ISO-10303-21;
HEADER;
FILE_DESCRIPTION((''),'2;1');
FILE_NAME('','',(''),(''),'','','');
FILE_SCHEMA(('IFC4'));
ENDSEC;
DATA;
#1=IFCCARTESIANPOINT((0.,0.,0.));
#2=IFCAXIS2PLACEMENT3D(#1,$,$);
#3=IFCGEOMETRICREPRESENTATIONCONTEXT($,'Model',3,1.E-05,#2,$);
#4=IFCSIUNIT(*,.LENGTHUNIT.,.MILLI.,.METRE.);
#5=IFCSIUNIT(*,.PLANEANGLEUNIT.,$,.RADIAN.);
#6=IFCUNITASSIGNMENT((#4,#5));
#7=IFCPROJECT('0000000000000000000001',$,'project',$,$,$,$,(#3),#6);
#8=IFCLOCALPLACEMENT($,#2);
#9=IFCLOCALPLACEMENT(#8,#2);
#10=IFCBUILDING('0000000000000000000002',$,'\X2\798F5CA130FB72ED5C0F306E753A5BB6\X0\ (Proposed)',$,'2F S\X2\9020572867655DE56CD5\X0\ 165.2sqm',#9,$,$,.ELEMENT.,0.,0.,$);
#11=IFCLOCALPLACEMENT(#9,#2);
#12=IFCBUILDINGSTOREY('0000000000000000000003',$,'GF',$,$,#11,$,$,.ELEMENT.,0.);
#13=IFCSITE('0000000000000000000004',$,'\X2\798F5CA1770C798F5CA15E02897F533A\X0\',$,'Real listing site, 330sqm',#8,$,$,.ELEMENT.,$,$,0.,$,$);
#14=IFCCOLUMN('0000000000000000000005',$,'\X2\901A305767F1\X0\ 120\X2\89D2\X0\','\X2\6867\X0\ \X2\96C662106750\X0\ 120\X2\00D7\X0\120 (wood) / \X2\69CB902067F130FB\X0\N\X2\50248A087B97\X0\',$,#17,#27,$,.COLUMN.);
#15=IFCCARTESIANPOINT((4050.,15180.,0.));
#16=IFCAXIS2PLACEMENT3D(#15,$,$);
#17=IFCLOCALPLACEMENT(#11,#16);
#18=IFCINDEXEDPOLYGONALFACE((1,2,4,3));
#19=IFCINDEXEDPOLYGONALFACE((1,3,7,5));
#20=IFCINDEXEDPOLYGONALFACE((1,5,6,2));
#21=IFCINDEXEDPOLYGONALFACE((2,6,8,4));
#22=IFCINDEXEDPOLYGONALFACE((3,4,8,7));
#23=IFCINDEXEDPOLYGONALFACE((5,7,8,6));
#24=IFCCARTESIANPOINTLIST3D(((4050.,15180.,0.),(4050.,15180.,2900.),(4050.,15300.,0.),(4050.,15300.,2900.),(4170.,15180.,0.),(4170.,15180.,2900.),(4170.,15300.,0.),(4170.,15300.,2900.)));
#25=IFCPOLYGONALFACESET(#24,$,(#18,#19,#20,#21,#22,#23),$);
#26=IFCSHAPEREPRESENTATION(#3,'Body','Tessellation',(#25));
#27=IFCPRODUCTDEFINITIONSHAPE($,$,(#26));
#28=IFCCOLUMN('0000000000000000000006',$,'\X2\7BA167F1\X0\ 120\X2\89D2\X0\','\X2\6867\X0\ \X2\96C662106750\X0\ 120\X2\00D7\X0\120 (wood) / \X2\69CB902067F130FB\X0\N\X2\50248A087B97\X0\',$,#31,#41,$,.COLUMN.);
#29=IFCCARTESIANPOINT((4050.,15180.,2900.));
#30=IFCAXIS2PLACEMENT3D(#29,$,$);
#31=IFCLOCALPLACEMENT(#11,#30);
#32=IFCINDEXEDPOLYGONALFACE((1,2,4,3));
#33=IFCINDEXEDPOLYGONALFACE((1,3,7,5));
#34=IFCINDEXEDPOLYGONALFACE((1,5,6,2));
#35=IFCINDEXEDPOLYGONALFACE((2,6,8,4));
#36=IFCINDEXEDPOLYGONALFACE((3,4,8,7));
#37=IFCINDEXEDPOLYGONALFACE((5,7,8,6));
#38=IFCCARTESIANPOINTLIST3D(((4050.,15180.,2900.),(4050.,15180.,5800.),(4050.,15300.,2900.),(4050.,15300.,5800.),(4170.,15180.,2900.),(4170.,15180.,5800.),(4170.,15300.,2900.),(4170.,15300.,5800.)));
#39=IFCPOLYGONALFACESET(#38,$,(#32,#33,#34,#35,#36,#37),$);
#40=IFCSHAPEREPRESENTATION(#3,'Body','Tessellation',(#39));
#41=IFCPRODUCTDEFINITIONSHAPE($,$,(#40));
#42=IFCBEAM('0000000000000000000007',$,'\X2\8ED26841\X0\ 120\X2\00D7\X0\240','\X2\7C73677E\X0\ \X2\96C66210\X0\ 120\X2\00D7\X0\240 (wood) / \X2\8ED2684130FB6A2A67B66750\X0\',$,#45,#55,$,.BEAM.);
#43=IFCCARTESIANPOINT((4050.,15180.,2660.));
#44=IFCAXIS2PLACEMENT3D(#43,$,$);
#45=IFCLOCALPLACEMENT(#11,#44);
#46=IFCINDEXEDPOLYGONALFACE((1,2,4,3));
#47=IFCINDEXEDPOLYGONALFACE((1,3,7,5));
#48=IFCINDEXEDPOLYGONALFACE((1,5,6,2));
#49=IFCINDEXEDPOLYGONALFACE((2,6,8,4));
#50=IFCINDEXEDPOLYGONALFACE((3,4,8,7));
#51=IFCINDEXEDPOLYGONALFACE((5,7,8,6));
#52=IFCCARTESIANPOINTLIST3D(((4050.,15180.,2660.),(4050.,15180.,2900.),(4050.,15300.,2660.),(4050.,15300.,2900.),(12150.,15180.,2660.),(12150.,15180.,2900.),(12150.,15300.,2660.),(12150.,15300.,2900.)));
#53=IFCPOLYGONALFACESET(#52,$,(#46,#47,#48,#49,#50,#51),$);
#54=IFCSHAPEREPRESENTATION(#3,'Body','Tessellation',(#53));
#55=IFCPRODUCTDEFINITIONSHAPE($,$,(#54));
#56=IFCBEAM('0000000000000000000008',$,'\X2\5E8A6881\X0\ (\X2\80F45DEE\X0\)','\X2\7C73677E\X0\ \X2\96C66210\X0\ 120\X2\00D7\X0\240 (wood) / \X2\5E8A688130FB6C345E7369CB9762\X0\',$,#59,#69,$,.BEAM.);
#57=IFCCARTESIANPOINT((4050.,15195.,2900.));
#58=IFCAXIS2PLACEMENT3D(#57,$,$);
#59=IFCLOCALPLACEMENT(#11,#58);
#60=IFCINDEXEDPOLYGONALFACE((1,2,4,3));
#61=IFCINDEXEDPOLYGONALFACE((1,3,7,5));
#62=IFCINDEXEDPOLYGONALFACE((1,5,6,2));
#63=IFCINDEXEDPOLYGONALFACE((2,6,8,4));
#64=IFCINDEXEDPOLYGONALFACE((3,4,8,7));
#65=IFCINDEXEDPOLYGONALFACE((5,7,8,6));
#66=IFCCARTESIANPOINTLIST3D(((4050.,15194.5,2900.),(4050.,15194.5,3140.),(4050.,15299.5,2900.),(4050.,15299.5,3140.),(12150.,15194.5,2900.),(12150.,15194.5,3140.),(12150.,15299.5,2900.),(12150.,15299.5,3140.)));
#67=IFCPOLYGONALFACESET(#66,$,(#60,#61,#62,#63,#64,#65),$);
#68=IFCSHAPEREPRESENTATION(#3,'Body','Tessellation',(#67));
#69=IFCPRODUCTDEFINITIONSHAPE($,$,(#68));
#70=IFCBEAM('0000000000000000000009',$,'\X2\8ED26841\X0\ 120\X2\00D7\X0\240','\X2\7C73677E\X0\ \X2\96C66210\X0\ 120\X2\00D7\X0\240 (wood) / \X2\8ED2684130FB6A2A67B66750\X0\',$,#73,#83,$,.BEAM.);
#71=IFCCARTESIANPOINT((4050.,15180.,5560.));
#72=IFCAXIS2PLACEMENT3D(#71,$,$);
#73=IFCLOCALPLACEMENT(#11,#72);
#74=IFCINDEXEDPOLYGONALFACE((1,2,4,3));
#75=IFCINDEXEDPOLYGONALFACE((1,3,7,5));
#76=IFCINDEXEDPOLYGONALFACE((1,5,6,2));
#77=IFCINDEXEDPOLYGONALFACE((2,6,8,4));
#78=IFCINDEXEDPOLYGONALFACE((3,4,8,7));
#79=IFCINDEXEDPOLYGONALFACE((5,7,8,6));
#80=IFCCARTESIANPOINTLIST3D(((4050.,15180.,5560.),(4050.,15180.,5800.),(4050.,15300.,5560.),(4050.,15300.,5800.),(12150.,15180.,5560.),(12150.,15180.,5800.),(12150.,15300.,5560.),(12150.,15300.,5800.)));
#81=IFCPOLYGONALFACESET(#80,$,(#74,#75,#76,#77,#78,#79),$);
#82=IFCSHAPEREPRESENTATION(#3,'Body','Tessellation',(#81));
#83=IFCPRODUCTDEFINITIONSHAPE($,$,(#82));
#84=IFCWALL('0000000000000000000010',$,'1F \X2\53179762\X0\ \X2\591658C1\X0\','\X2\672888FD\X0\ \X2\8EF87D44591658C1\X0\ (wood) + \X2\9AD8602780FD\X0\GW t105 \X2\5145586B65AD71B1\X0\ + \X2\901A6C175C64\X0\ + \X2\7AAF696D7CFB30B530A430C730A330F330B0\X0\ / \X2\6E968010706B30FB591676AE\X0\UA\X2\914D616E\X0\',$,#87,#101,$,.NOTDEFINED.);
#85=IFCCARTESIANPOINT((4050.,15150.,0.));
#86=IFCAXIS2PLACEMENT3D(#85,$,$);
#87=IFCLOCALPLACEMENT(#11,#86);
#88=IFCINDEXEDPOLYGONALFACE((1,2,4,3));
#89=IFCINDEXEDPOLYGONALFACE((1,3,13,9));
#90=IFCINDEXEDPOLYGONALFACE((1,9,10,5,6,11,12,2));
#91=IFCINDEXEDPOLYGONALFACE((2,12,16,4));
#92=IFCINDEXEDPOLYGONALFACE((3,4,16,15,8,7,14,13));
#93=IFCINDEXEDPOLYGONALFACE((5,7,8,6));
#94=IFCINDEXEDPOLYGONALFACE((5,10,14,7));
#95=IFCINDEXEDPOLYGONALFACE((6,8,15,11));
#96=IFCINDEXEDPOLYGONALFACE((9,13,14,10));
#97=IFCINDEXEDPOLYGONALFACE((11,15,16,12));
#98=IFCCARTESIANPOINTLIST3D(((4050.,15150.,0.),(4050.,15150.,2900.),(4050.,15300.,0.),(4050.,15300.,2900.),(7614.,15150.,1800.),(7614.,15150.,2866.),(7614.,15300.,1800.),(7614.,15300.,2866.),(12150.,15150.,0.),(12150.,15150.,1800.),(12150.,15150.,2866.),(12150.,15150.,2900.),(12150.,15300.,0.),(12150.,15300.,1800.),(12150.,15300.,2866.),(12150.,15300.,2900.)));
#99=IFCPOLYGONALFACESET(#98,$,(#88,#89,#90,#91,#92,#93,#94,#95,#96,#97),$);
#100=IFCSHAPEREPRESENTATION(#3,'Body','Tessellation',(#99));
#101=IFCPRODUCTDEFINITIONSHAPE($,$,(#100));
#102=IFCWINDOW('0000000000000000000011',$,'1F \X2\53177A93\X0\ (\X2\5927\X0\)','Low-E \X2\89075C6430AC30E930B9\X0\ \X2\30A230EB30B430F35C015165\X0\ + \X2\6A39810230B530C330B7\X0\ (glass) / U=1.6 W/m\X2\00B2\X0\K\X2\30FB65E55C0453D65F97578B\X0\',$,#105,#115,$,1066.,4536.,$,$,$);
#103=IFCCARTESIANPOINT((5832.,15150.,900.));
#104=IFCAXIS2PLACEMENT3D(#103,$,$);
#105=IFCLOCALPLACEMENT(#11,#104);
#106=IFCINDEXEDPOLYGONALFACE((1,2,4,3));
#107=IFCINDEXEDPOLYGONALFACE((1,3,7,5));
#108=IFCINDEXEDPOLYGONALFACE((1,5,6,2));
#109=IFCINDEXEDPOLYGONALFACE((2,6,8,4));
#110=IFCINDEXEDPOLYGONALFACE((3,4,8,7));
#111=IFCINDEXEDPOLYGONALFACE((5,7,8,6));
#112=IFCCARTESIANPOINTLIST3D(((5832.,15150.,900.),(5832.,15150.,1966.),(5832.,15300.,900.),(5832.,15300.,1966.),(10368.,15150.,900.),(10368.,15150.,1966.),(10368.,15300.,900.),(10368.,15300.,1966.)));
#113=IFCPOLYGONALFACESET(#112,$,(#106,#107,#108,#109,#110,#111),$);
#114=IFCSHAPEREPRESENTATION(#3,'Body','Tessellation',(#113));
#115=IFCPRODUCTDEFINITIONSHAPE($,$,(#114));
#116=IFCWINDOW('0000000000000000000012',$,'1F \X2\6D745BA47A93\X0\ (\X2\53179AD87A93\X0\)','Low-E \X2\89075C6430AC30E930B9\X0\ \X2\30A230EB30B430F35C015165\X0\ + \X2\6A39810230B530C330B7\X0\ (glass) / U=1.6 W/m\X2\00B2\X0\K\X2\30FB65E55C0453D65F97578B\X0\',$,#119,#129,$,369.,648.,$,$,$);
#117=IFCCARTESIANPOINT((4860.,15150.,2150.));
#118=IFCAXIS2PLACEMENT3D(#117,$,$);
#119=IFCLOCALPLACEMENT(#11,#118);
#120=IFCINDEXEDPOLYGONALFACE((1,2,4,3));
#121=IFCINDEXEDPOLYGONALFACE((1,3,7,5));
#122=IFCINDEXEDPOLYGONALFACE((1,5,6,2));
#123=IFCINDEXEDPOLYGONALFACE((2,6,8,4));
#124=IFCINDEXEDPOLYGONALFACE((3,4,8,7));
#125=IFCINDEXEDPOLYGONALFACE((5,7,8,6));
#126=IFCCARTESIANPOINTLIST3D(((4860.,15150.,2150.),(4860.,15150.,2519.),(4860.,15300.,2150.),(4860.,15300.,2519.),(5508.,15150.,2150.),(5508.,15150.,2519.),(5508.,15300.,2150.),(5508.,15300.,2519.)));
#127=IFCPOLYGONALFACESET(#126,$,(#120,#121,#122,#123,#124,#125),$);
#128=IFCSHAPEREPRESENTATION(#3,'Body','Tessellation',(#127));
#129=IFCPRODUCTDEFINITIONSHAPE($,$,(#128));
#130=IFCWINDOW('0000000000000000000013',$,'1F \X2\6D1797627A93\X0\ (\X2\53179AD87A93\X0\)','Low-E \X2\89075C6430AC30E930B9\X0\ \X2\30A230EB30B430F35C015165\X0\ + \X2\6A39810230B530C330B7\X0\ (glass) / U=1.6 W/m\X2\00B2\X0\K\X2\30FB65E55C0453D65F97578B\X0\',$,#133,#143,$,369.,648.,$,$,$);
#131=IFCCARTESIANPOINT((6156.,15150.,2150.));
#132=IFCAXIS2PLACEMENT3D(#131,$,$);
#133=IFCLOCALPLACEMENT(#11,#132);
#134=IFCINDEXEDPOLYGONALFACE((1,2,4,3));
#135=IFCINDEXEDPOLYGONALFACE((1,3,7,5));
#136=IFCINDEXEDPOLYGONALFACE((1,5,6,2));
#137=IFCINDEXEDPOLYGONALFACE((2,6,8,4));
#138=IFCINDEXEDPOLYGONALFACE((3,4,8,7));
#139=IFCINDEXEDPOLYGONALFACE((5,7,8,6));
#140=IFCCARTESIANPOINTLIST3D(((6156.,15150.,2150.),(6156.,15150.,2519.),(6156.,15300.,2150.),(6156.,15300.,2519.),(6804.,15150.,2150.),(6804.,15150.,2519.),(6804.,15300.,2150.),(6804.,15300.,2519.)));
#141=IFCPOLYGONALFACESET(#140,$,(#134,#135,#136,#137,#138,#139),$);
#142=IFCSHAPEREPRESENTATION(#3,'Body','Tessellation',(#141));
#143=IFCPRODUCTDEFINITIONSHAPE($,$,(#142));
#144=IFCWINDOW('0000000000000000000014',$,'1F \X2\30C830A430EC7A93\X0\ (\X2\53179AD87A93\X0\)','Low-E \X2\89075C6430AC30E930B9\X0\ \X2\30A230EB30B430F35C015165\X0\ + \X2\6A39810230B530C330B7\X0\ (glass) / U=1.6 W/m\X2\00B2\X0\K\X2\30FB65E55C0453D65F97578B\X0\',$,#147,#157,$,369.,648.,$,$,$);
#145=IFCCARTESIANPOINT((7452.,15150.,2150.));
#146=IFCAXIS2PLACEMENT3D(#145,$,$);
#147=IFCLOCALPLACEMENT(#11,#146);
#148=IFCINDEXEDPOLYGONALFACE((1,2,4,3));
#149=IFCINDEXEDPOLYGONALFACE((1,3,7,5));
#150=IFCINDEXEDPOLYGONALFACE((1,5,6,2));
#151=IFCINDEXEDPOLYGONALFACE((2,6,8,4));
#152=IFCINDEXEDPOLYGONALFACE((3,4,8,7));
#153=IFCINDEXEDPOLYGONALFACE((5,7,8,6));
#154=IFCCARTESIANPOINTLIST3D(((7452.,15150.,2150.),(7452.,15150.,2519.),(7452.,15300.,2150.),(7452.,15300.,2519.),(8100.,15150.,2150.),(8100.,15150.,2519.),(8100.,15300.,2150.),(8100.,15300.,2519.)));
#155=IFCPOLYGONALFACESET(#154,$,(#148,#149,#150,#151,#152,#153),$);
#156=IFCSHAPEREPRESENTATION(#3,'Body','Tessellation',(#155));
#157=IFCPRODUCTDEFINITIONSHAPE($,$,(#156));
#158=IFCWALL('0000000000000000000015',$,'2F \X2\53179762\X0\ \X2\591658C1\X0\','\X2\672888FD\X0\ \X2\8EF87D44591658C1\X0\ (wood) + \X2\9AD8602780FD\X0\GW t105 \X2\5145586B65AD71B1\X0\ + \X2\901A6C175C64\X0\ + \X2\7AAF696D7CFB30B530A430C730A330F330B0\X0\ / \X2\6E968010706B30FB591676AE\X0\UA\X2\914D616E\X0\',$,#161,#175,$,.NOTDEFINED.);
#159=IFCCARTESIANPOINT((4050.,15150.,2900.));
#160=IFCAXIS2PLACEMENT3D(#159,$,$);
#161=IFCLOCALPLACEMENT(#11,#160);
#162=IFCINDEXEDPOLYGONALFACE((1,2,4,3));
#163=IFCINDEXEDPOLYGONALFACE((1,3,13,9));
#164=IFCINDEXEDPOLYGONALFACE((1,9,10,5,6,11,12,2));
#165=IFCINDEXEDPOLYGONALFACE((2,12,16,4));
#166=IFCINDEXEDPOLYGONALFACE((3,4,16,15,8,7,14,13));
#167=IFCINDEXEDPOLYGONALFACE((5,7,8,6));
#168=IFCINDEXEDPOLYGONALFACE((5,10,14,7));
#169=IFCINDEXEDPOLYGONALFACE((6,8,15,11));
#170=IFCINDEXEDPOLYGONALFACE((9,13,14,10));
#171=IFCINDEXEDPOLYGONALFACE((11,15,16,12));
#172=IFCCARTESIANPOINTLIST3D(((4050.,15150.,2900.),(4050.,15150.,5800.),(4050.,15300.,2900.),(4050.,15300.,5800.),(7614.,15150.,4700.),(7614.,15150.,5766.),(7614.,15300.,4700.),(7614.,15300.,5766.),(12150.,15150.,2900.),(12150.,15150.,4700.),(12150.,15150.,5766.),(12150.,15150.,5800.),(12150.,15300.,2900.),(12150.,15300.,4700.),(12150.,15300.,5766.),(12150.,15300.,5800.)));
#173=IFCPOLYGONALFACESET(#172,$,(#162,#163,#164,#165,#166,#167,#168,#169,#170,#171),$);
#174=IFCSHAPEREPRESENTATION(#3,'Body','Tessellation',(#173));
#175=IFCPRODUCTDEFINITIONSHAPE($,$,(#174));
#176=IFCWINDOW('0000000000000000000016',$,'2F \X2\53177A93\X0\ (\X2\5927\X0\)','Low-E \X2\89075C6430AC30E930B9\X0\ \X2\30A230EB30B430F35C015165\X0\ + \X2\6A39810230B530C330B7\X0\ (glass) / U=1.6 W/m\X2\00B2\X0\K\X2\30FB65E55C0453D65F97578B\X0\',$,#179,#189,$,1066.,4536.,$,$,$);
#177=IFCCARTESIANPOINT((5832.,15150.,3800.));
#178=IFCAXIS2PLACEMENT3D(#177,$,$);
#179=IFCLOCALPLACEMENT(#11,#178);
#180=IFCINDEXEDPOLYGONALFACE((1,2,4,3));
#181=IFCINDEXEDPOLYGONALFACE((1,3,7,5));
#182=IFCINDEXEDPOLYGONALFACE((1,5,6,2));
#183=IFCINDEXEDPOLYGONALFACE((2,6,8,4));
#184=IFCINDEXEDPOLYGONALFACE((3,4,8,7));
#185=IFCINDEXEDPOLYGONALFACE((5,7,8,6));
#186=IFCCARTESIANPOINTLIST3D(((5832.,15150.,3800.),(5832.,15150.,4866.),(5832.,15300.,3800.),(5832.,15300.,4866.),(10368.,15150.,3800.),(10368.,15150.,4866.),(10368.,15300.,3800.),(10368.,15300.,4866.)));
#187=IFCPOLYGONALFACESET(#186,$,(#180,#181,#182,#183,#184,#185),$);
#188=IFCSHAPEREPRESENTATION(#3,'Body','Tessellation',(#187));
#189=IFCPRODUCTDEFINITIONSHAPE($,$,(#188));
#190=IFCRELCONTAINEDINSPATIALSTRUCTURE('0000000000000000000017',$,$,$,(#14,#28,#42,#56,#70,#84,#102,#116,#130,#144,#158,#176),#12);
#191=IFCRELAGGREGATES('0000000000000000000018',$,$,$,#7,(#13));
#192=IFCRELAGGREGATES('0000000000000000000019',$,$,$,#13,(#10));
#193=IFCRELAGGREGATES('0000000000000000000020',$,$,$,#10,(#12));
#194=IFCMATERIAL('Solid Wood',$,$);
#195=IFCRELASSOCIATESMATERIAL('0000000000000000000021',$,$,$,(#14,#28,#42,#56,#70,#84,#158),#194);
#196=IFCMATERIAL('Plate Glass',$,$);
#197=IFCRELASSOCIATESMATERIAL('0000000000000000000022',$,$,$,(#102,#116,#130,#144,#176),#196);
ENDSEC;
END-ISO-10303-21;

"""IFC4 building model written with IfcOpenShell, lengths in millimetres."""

from ifc_helpers import new_model, si_unit, frame, frame_2d, origin, place, context, project, spatial, rectangle, extrude, material, element, fill, save


model = new_model("IFC4")

# Units and contexts
model_context = context("Model", 3, precision=1e-05, world=origin())
ifc_project = project(units=[si_unit("LENGTHUNIT", "METRE", prefix="MILLI"), si_unit("PLANEANGLEUNIT", "RADIAN")], contexts=[model_context])

# Site, building, storey
site_placement = place(None, origin())
site = spatial("IfcSite", under=ifc_project, at=site_placement, Name="福岡県福岡市西区", ObjectType="Real listing site, 330sqm", CompositionType="ELEMENT", RefElevation=0.0)
building_placement = place(site_placement, origin())
building = spatial("IfcBuilding", under=site, at=building_placement, Name="福岡・狭小の町家 (Proposed)", ObjectType="2F S造在来工法 165.2sqm", CompositionType="ELEMENT", ElevationOfRefHeight=0.0, ElevationOfTerrain=0.0)
storey_placement = place(building_placement, origin())
storey = spatial("IfcBuildingStorey", under=building, at=storey_placement, Name="GF", CompositionType="ELEMENT", Elevation=0.0)

# Columns
ifc_material_1 = material(Name="Solid Wood")
column_1_placement = place(storey_placement, frame((4050.0, 15180.0, 0.0)))
element("IfcColumn", 1, at=column_1_placement, inside=storey, material=ifc_material_1, Name="通し柱 120角", Description="桧 集成材 120×120 (wood) / 構造柱・N値計算", PredefinedType="COLUMN", context=model_context, shape_type="SweptSolid", body=[
    extrude(rectangle(XDim=120.0, YDim=120.0, at=frame_2d((60.0, 60.0))), frame((4050.0, 15180.0, 0.0)), (0.0, 0.0, 1.0), 2900.0),
])
column_2_placement = place(storey_placement, frame((4050.0, 15180.0, 2900.0)))
element("IfcColumn", 2, at=column_2_placement, inside=storey, material=ifc_material_1, Name="管柱 120角", Description="桧 集成材 120×120 (wood) / 構造柱・N値計算", PredefinedType="COLUMN", context=model_context, shape_type="SweptSolid", body=[
    extrude(rectangle(XDim=120.0, YDim=120.0, at=frame_2d((60.0, 60.0))), frame((4050.0, 15180.0, 2900.0)), (0.0, 0.0, 1.0), 2900.0),
])

# Beams
beam_1_placement = place(storey_placement, frame((4050.0, 15180.0, 2660.0)))
element("IfcBeam", 3, at=beam_1_placement, inside=storey, material=ifc_material_1, Name="軒桁 120×240", Description="米松 集成 120×240 (wood) / 軒桁・横架材", PredefinedType="BEAM", context=model_context, shape_type="SweptSolid", body=[
    extrude(rectangle(XDim=8100.0, YDim=120.0, at=frame_2d((4050.0, 60.0))), frame((4050.0, 15180.0, 2660.0)), (0.0, 0.0, 1.0), 240.0),
])
beam_2_placement = place(storey_placement, frame((4050.0, 15195.0, 2900.0)))
element("IfcBeam", 4, at=beam_2_placement, inside=storey, material=ifc_material_1, Name="床梁 (胴差)", Description="米松 集成 120×240 (wood) / 床梁・水平構面", PredefinedType="BEAM", context=model_context, shape_type="SweptSolid", body=[
    extrude(rectangle(XDim=8100.0, YDim=105.0, at=frame_2d((4050.0, 52.0))), frame((4050.0, 15195.0, 2900.0)), (0.0, 0.0, 1.0), 240.0),
])
beam_3_placement = place(storey_placement, frame((4050.0, 15180.0, 5560.0)))
element("IfcBeam", 5, at=beam_3_placement, inside=storey, material=ifc_material_1, Name="軒桁 120×240", Description="米松 集成 120×240 (wood) / 軒桁・横架材", PredefinedType="BEAM", context=model_context, shape_type="SweptSolid", body=[
    extrude(rectangle(XDim=8100.0, YDim=120.0, at=frame_2d((4050.0, 60.0))), frame((4050.0, 15180.0, 5560.0)), (0.0, 0.0, 1.0), 240.0),
])

# Wall, openings, windows
wall_1_placement = place(storey_placement, frame((4050.0, 15150.0, 0.0)))
wall_1 = element("IfcWall", 6, at=wall_1_placement, inside=storey, material=ifc_material_1, Name="1F 北面 外壁", Description="木製 軸組外壁 (wood) + 高性能GW t105 充填断熱 + 通気層 + 窯業系サイディング / 準耐火・外皮UA配慮", PredefinedType="NOTDEFINED", context=model_context, shape_type="SweptSolid", body=[
    extrude(rectangle(XDim=8100.0, YDim=150.0, at=frame_2d((4050.0, 75.0))), frame((4050.0, 15150.0, 0.0)), (0.0, 0.0, 1.0), 2900.0),
])
opening_1_placement = place(storey_placement, frame((5832.0, 15150.0, 900.0)))
opening_1 = element("IfcOpeningElement", 7, at=opening_1_placement, cuts=wall_1, PredefinedType="NOTDEFINED", context=model_context, shape_type="SweptSolid", body=[
    extrude(rectangle(XDim=4536.0, YDim=150.0, at=frame_2d((2268.0, 75.0))), frame((5832.0, 15150.0, 900.0)), (0.0, 0.0, 1.0), 1066.0),
])
opening_2_placement = place(storey_placement, frame((4860.0, 15150.0, 2150.0)))
opening_2 = element("IfcOpeningElement", 8, at=opening_2_placement, cuts=wall_1, PredefinedType="NOTDEFINED", context=model_context, shape_type="SweptSolid", body=[
    extrude(rectangle(XDim=648.0, YDim=150.0, at=frame_2d((324.0, 75.0))), frame((4860.0, 15150.0, 2150.0)), (0.0, 0.0, 1.0), 369.0),
])
opening_3_placement = place(storey_placement, frame((6156.0, 15150.0, 2150.0)))
opening_3 = element("IfcOpeningElement", 9, at=opening_3_placement, cuts=wall_1, PredefinedType="NOTDEFINED", context=model_context, shape_type="SweptSolid", body=[
    extrude(rectangle(XDim=648.0, YDim=150.0, at=frame_2d((324.0, 75.0))), frame((6156.0, 15150.0, 2150.0)), (0.0, 0.0, 1.0), 369.0),
])
opening_4_placement = place(storey_placement, frame((7452.0, 15150.0, 2150.0)))
opening_4 = element("IfcOpeningElement", 10, at=opening_4_placement, cuts=wall_1, PredefinedType="NOTDEFINED", context=model_context, shape_type="SweptSolid", body=[
    extrude(rectangle(XDim=648.0, YDim=150.0, at=frame_2d((324.0, 75.0))), frame((7452.0, 15150.0, 2150.0)), (0.0, 0.0, 1.0), 369.0),
])
ifc_material_2 = material(Name="Plate Glass")
window_1_placement = place(storey_placement, frame((5832.0, 15150.0, 900.0)))
window_1 = element("IfcWindow", 11, at=window_1_placement, inside=storey, material=ifc_material_2, Name="1F 北窓 (大)", Description="Low-E 複層ガラス アルゴン封入 + 樹脂サッシ (glass) / U=1.6 W/m²K・日射取得型", OverallHeight=1066.0, OverallWidth=4536.0, context=model_context, shape_type="SweptSolid", body=[
    extrude(rectangle(XDim=4536.0, YDim=150.0, at=frame_2d((2268.0, 75.0))), frame((5832.0, 15150.0, 900.0)), (0.0, 0.0, 1.0), 1066.0),
])
fill(opening_1, window_1)
window_2_placement = place(storey_placement, frame((4860.0, 15150.0, 2150.0)))
window_2 = element("IfcWindow", 12, at=window_2_placement, inside=storey, material=ifc_material_2, Name="1F 浴室窓 (北高窓)", Description="Low-E 複層ガラス アルゴン封入 + 樹脂サッシ (glass) / U=1.6 W/m²K・日射取得型", OverallHeight=369.0, OverallWidth=648.0, context=model_context, shape_type="SweptSolid", body=[
    extrude(rectangle(XDim=648.0, YDim=150.0, at=frame_2d((324.0, 75.0))), frame((4860.0, 15150.0, 2150.0)), (0.0, 0.0, 1.0), 369.0),
])
fill(opening_2, window_2)
window_3_placement = place(storey_placement, frame((6156.0, 15150.0, 2150.0)))
window_3 = element("IfcWindow", 13, at=window_3_placement, inside=storey, material=ifc_material_2, Name="1F 洗面窓 (北高窓)", Description="Low-E 複層ガラス アルゴン封入 + 樹脂サッシ (glass) / U=1.6 W/m²K・日射取得型", OverallHeight=369.0, OverallWidth=648.0, context=model_context, shape_type="SweptSolid", body=[
    extrude(rectangle(XDim=648.0, YDim=150.0, at=frame_2d((324.0, 75.0))), frame((6156.0, 15150.0, 2150.0)), (0.0, 0.0, 1.0), 369.0),
])
fill(opening_3, window_3)
window_4_placement = place(storey_placement, frame((7452.0, 15150.0, 2150.0)))
window_4 = element("IfcWindow", 14, at=window_4_placement, inside=storey, material=ifc_material_2, Name="1F トイレ窓 (北高窓)", Description="Low-E 複層ガラス アルゴン封入 + 樹脂サッシ (glass) / U=1.6 W/m²K・日射取得型", OverallHeight=369.0, OverallWidth=648.0, context=model_context, shape_type="SweptSolid", body=[
    extrude(rectangle(XDim=648.0, YDim=150.0, at=frame_2d((324.0, 75.0))), frame((7452.0, 15150.0, 2150.0)), (0.0, 0.0, 1.0), 369.0),
])
fill(opening_4, window_4)

# Wall, opening, window
wall_2_placement = place(storey_placement, frame((4050.0, 15150.0, 2900.0)))
wall_2 = element("IfcWall", 15, at=wall_2_placement, inside=storey, material=ifc_material_1, Name="2F 北面 外壁", Description="木製 軸組外壁 (wood) + 高性能GW t105 充填断熱 + 通気層 + 窯業系サイディング / 準耐火・外皮UA配慮", PredefinedType="NOTDEFINED", context=model_context, shape_type="SweptSolid", body=[
    extrude(rectangle(XDim=8100.0, YDim=150.0, at=frame_2d((4050.0, 75.0))), frame((4050.0, 15150.0, 2900.0)), (0.0, 0.0, 1.0), 2900.0),
])
opening_5_placement = place(storey_placement, frame((5832.0, 15150.0, 3800.0)))
opening_5 = element("IfcOpeningElement", 16, at=opening_5_placement, cuts=wall_2, PredefinedType="NOTDEFINED", context=model_context, shape_type="SweptSolid", body=[
    extrude(rectangle(XDim=4536.0, YDim=150.0, at=frame_2d((2268.0, 75.0))), frame((5832.0, 15150.0, 3800.0)), (0.0, 0.0, 1.0), 1066.0),
])
window_5_placement = place(storey_placement, frame((5832.0, 15150.0, 3800.0)))
window_5 = element("IfcWindow", 17, at=window_5_placement, inside=storey, material=ifc_material_2, Name="2F 北窓 (大)", Description="Low-E 複層ガラス アルゴン封入 + 樹脂サッシ (glass) / U=1.6 W/m²K・日射取得型", OverallHeight=1066.0, OverallWidth=4536.0, context=model_context, shape_type="SweptSolid", body=[
    extrude(rectangle(XDim=4536.0, YDim=150.0, at=frame_2d((2268.0, 75.0))), frame((5832.0, 15150.0, 3800.0)), (0.0, 0.0, 1.0), 1066.0),
])
fill(opening_5, window_5)

save(model, "model.ifc")
